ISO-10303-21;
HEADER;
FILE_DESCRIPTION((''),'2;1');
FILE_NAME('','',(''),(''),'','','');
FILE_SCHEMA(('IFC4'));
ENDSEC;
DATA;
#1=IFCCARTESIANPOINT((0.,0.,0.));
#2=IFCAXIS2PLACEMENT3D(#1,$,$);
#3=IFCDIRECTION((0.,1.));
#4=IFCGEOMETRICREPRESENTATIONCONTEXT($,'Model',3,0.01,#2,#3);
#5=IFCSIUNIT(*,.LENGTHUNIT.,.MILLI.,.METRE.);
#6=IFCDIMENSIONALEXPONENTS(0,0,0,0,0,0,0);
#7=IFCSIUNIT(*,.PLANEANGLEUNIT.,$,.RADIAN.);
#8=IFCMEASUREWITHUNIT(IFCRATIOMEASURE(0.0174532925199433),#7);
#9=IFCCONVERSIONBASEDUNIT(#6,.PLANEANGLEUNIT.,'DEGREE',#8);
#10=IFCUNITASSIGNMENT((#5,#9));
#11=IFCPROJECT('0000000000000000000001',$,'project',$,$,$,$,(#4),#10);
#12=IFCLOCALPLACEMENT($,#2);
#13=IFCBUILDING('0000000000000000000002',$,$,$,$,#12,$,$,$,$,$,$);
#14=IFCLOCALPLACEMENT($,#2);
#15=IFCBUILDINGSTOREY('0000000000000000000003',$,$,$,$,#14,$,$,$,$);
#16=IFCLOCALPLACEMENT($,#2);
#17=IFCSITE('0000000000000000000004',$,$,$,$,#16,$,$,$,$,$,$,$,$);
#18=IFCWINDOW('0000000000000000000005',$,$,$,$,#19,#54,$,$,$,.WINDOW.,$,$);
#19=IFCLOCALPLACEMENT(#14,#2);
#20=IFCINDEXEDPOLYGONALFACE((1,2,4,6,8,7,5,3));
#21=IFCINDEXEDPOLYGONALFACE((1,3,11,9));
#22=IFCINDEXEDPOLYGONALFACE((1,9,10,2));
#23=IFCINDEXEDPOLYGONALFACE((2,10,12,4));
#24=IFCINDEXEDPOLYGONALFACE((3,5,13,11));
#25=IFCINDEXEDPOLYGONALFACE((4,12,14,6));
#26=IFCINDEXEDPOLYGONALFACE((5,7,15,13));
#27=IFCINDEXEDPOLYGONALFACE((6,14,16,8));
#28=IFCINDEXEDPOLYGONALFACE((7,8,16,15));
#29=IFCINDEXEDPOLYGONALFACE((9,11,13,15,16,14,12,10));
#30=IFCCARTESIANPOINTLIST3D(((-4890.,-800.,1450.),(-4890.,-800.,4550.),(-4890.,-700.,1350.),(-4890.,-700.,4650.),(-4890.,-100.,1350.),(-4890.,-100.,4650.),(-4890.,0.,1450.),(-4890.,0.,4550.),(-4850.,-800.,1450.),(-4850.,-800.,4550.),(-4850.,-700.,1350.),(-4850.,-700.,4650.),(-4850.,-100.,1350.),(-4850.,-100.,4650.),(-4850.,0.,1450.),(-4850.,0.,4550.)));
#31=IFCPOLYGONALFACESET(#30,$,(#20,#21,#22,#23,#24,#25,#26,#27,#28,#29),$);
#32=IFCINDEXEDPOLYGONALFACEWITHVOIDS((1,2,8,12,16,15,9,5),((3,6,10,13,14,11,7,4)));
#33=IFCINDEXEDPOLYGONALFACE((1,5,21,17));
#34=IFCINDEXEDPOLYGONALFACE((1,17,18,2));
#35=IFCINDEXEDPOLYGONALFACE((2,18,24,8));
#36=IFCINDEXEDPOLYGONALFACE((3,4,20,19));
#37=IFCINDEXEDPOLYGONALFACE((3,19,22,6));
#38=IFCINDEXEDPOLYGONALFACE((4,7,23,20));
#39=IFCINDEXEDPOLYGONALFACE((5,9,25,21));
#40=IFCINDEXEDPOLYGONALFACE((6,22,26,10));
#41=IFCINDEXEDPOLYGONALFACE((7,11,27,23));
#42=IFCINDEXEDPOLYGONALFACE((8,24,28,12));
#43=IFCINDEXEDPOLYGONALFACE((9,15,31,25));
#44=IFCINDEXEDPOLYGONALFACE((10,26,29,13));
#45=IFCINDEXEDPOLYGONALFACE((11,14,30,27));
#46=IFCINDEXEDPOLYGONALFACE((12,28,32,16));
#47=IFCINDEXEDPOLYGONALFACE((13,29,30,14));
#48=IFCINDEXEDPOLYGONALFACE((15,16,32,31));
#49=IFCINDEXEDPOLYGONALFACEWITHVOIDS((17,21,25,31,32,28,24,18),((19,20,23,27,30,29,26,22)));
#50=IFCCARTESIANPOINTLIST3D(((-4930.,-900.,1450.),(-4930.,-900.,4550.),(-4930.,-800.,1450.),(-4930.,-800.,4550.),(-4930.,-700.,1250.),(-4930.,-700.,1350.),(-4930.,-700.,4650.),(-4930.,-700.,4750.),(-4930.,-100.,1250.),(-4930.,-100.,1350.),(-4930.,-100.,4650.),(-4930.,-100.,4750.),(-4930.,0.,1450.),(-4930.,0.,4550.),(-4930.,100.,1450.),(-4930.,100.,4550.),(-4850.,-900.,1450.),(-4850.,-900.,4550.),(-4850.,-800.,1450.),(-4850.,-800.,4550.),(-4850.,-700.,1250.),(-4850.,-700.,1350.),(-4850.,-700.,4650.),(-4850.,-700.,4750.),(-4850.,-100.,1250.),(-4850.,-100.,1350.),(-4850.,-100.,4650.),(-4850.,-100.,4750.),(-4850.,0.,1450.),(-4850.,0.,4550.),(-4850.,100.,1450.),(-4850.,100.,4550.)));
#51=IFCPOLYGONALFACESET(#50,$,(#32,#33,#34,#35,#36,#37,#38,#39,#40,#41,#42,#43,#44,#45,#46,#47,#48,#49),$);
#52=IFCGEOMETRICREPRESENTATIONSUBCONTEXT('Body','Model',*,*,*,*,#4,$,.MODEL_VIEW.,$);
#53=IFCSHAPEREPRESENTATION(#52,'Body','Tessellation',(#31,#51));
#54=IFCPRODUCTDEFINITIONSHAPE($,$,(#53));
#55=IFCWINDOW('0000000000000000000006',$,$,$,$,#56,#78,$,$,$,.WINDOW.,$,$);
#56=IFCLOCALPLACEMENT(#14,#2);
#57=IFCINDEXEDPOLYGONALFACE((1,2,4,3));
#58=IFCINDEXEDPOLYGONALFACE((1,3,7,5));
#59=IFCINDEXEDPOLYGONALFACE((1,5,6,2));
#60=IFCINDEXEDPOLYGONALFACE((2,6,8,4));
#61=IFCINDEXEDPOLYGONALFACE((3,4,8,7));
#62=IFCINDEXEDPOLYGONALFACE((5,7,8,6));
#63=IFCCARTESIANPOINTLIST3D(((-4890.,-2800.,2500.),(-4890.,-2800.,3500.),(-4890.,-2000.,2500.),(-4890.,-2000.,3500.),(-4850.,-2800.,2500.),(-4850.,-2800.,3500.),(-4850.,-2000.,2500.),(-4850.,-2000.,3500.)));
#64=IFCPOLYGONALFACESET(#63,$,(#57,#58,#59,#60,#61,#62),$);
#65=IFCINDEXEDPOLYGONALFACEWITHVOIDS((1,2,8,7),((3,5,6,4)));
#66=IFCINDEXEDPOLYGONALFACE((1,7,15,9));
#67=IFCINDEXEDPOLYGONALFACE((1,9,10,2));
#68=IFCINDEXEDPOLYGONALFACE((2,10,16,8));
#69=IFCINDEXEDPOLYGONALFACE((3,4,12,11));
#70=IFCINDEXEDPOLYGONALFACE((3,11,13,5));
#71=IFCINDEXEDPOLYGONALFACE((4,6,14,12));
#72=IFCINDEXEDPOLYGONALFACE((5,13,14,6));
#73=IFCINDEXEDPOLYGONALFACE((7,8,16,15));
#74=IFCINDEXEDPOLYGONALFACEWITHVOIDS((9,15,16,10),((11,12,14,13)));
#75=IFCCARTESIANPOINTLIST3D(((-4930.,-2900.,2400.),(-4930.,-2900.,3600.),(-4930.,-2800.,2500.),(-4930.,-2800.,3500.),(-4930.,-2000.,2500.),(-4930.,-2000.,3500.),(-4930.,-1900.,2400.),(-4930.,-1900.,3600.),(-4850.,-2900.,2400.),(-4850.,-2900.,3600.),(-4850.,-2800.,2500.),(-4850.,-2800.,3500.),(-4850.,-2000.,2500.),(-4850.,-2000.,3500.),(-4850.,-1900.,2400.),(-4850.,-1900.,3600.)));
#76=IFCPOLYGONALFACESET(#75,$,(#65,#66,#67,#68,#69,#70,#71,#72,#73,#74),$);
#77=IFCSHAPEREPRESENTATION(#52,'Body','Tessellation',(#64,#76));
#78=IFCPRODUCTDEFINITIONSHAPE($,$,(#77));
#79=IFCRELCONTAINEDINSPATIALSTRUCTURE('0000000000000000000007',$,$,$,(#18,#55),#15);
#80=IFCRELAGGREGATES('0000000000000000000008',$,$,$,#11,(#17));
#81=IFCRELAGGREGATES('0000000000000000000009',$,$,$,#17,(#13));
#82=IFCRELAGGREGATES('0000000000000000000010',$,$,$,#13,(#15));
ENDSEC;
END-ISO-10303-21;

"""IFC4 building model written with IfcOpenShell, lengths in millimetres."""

from ifc_helpers import new_model, entity, si_unit, converted_unit, direction, frame, origin, place, context, subcontext, project, spatial, element, save


model = new_model("IFC4")

# Units and contexts
model_context = context("Model", 3, precision=0.01, world=origin(), true_north=direction((0.0, 1.0)))
body_context = subcontext(model_context, "Body", "Model", "MODEL_VIEW")
ifc_project = project(units=[si_unit("LENGTHUNIT", "METRE", prefix="MILLI"), converted_unit("PLANEANGLEUNIT", "DEGREE", entity("IfcRatioMeasure", 0.0174532925199433), si_unit("PLANEANGLEUNIT", "RADIAN"), dimensions=[0, 0, 0, 0, 0, 0, 0])], contexts=[model_context])

# Site, building, storey
site_placement = place(None, origin())
site = spatial("IfcSite", under=ifc_project, at=site_placement)
building_placement = place(None, origin())
building = spatial("IfcBuilding", under=site, at=building_placement)
storey_placement = place(None, origin())
storey = spatial("IfcBuildingStorey", under=building, at=storey_placement)

# Shared definitions
cartesian_point_1 = entity("IfcCartesianPoint", [-400.0, -1550.0])
shared_polyline_1 = entity("IfcPolyline", [cartesian_point_1, entity("IfcCartesianPoint", [-400.0, 1550.0]), entity("IfcCartesianPoint", [-300.0, 1650.0]), entity("IfcCartesianPoint", [300.0, 1650.0]), entity("IfcCartesianPoint", [400.0, 1550.0]), entity("IfcCartesianPoint", [400.0, -1550.0]), entity("IfcCartesianPoint", [300.0, -1650.0]), entity("IfcCartesianPoint", [-300.0, -1650.0]), cartesian_point_1])
cartesian_point_2 = entity("IfcCartesianPoint", [-400.0, -500.0])
shared_polyline_2 = entity("IfcPolyline", [cartesian_point_2, entity("IfcCartesianPoint", [-400.0, 500.0]), entity("IfcCartesianPoint", [-400.0, 500.0]), entity("IfcCartesianPoint", [400.0, 500.0]), entity("IfcCartesianPoint", [400.0, 500.0]), entity("IfcCartesianPoint", [400.0, -500.0]), entity("IfcCartesianPoint", [400.0, -500.0]), entity("IfcCartesianPoint", [-400.0, -500.0]), cartesian_point_2])

# Shared definitions
wall_1_placement = place(storey_placement, frame((-4900.0, 100.0, 0.0), z_axis=(0.0, 0.0, 1.0), x_axis=(0.0, -1.0, 0.0)))
window_1_placement = place(wall_1_placement, frame((500.0, 50.0, 3000.0)))
window_2_placement = place(wall_1_placement, frame((2500.0, 50.0, 3000.0)))

# Windows
cartesian_point_3 = entity("IfcCartesianPoint", [-500.0, -1550.0])
element("IfcWindow", 1, at=window_1_placement, inside=storey, PredefinedType="WINDOW", context=body_context, shape_type="SweptSolid", body=[
    entity("IfcExtrudedAreaSolid", entity("IfcArbitraryClosedProfileDef", "AREA", None, shared_polyline_1), entity("IfcAxis2Placement3D", entity("IfcCartesianPoint", [0.0, 0.0, 0.0]), entity("IfcDirection", [0.0, -1.0, 0.0]), entity("IfcDirection", [1.0, 0.0, 0.0])), entity("IfcDirection", [0.0, 0.0, 1.0]), 40.0),
    entity("IfcExtrudedAreaSolid", entity("IfcArbitraryProfileDefWithVoids", "AREA", None, entity("IfcPolyline", [cartesian_point_3, entity("IfcCartesianPoint", [-500.0, 1550.0]), entity("IfcCartesianPoint", [-300.0, 1750.0]), entity("IfcCartesianPoint", [300.0, 1750.0]), entity("IfcCartesianPoint", [500.0, 1550.0]), entity("IfcCartesianPoint", [500.0, -1550.0]), entity("IfcCartesianPoint", [300.0, -1750.0]), entity("IfcCartesianPoint", [-300.0, -1750.0]), cartesian_point_3]), [shared_polyline_1]), entity("IfcAxis2Placement3D", entity("IfcCartesianPoint", [0.0, 0.0, 0.0]), entity("IfcDirection", [0.0, -1.0, 0.0]), entity("IfcDirection", [1.0, 0.0, 0.0])), entity("IfcDirection", [0.0, 0.0, 1.0]), 80.0),
])
cartesian_point_4 = entity("IfcCartesianPoint", [-500.0, -600.0])
element("IfcWindow", 2, at=window_2_placement, inside=storey, PredefinedType="WINDOW", context=body_context, shape_type="SweptSolid", body=[
    entity("IfcExtrudedAreaSolid", entity("IfcArbitraryClosedProfileDef", "AREA", None, shared_polyline_2), entity("IfcAxis2Placement3D", entity("IfcCartesianPoint", [0.0, 0.0, 0.0]), entity("IfcDirection", [0.0, -1.0, 0.0]), entity("IfcDirection", [1.0, 0.0, 0.0])), entity("IfcDirection", [0.0, 0.0, 1.0]), 40.0),
    entity("IfcExtrudedAreaSolid", entity("IfcArbitraryProfileDefWithVoids", "AREA", None, entity("IfcPolyline", [cartesian_point_4, entity("IfcCartesianPoint", [-500.0, 600.0]), entity("IfcCartesianPoint", [-500.0, 600.0]), entity("IfcCartesianPoint", [500.0, 600.0]), entity("IfcCartesianPoint", [500.0, 600.0]), entity("IfcCartesianPoint", [500.0, -600.0]), entity("IfcCartesianPoint", [500.0, -600.0]), entity("IfcCartesianPoint", [-500.0, -600.0]), cartesian_point_4]), [shared_polyline_2]), entity("IfcAxis2Placement3D", entity("IfcCartesianPoint", [0.0, 0.0, 0.0]), entity("IfcDirection", [0.0, -1.0, 0.0]), entity("IfcDirection", [1.0, 0.0, 0.0])), entity("IfcDirection", [0.0, 0.0, 1.0]), 80.0),
])

save(model, "model.ifc")
